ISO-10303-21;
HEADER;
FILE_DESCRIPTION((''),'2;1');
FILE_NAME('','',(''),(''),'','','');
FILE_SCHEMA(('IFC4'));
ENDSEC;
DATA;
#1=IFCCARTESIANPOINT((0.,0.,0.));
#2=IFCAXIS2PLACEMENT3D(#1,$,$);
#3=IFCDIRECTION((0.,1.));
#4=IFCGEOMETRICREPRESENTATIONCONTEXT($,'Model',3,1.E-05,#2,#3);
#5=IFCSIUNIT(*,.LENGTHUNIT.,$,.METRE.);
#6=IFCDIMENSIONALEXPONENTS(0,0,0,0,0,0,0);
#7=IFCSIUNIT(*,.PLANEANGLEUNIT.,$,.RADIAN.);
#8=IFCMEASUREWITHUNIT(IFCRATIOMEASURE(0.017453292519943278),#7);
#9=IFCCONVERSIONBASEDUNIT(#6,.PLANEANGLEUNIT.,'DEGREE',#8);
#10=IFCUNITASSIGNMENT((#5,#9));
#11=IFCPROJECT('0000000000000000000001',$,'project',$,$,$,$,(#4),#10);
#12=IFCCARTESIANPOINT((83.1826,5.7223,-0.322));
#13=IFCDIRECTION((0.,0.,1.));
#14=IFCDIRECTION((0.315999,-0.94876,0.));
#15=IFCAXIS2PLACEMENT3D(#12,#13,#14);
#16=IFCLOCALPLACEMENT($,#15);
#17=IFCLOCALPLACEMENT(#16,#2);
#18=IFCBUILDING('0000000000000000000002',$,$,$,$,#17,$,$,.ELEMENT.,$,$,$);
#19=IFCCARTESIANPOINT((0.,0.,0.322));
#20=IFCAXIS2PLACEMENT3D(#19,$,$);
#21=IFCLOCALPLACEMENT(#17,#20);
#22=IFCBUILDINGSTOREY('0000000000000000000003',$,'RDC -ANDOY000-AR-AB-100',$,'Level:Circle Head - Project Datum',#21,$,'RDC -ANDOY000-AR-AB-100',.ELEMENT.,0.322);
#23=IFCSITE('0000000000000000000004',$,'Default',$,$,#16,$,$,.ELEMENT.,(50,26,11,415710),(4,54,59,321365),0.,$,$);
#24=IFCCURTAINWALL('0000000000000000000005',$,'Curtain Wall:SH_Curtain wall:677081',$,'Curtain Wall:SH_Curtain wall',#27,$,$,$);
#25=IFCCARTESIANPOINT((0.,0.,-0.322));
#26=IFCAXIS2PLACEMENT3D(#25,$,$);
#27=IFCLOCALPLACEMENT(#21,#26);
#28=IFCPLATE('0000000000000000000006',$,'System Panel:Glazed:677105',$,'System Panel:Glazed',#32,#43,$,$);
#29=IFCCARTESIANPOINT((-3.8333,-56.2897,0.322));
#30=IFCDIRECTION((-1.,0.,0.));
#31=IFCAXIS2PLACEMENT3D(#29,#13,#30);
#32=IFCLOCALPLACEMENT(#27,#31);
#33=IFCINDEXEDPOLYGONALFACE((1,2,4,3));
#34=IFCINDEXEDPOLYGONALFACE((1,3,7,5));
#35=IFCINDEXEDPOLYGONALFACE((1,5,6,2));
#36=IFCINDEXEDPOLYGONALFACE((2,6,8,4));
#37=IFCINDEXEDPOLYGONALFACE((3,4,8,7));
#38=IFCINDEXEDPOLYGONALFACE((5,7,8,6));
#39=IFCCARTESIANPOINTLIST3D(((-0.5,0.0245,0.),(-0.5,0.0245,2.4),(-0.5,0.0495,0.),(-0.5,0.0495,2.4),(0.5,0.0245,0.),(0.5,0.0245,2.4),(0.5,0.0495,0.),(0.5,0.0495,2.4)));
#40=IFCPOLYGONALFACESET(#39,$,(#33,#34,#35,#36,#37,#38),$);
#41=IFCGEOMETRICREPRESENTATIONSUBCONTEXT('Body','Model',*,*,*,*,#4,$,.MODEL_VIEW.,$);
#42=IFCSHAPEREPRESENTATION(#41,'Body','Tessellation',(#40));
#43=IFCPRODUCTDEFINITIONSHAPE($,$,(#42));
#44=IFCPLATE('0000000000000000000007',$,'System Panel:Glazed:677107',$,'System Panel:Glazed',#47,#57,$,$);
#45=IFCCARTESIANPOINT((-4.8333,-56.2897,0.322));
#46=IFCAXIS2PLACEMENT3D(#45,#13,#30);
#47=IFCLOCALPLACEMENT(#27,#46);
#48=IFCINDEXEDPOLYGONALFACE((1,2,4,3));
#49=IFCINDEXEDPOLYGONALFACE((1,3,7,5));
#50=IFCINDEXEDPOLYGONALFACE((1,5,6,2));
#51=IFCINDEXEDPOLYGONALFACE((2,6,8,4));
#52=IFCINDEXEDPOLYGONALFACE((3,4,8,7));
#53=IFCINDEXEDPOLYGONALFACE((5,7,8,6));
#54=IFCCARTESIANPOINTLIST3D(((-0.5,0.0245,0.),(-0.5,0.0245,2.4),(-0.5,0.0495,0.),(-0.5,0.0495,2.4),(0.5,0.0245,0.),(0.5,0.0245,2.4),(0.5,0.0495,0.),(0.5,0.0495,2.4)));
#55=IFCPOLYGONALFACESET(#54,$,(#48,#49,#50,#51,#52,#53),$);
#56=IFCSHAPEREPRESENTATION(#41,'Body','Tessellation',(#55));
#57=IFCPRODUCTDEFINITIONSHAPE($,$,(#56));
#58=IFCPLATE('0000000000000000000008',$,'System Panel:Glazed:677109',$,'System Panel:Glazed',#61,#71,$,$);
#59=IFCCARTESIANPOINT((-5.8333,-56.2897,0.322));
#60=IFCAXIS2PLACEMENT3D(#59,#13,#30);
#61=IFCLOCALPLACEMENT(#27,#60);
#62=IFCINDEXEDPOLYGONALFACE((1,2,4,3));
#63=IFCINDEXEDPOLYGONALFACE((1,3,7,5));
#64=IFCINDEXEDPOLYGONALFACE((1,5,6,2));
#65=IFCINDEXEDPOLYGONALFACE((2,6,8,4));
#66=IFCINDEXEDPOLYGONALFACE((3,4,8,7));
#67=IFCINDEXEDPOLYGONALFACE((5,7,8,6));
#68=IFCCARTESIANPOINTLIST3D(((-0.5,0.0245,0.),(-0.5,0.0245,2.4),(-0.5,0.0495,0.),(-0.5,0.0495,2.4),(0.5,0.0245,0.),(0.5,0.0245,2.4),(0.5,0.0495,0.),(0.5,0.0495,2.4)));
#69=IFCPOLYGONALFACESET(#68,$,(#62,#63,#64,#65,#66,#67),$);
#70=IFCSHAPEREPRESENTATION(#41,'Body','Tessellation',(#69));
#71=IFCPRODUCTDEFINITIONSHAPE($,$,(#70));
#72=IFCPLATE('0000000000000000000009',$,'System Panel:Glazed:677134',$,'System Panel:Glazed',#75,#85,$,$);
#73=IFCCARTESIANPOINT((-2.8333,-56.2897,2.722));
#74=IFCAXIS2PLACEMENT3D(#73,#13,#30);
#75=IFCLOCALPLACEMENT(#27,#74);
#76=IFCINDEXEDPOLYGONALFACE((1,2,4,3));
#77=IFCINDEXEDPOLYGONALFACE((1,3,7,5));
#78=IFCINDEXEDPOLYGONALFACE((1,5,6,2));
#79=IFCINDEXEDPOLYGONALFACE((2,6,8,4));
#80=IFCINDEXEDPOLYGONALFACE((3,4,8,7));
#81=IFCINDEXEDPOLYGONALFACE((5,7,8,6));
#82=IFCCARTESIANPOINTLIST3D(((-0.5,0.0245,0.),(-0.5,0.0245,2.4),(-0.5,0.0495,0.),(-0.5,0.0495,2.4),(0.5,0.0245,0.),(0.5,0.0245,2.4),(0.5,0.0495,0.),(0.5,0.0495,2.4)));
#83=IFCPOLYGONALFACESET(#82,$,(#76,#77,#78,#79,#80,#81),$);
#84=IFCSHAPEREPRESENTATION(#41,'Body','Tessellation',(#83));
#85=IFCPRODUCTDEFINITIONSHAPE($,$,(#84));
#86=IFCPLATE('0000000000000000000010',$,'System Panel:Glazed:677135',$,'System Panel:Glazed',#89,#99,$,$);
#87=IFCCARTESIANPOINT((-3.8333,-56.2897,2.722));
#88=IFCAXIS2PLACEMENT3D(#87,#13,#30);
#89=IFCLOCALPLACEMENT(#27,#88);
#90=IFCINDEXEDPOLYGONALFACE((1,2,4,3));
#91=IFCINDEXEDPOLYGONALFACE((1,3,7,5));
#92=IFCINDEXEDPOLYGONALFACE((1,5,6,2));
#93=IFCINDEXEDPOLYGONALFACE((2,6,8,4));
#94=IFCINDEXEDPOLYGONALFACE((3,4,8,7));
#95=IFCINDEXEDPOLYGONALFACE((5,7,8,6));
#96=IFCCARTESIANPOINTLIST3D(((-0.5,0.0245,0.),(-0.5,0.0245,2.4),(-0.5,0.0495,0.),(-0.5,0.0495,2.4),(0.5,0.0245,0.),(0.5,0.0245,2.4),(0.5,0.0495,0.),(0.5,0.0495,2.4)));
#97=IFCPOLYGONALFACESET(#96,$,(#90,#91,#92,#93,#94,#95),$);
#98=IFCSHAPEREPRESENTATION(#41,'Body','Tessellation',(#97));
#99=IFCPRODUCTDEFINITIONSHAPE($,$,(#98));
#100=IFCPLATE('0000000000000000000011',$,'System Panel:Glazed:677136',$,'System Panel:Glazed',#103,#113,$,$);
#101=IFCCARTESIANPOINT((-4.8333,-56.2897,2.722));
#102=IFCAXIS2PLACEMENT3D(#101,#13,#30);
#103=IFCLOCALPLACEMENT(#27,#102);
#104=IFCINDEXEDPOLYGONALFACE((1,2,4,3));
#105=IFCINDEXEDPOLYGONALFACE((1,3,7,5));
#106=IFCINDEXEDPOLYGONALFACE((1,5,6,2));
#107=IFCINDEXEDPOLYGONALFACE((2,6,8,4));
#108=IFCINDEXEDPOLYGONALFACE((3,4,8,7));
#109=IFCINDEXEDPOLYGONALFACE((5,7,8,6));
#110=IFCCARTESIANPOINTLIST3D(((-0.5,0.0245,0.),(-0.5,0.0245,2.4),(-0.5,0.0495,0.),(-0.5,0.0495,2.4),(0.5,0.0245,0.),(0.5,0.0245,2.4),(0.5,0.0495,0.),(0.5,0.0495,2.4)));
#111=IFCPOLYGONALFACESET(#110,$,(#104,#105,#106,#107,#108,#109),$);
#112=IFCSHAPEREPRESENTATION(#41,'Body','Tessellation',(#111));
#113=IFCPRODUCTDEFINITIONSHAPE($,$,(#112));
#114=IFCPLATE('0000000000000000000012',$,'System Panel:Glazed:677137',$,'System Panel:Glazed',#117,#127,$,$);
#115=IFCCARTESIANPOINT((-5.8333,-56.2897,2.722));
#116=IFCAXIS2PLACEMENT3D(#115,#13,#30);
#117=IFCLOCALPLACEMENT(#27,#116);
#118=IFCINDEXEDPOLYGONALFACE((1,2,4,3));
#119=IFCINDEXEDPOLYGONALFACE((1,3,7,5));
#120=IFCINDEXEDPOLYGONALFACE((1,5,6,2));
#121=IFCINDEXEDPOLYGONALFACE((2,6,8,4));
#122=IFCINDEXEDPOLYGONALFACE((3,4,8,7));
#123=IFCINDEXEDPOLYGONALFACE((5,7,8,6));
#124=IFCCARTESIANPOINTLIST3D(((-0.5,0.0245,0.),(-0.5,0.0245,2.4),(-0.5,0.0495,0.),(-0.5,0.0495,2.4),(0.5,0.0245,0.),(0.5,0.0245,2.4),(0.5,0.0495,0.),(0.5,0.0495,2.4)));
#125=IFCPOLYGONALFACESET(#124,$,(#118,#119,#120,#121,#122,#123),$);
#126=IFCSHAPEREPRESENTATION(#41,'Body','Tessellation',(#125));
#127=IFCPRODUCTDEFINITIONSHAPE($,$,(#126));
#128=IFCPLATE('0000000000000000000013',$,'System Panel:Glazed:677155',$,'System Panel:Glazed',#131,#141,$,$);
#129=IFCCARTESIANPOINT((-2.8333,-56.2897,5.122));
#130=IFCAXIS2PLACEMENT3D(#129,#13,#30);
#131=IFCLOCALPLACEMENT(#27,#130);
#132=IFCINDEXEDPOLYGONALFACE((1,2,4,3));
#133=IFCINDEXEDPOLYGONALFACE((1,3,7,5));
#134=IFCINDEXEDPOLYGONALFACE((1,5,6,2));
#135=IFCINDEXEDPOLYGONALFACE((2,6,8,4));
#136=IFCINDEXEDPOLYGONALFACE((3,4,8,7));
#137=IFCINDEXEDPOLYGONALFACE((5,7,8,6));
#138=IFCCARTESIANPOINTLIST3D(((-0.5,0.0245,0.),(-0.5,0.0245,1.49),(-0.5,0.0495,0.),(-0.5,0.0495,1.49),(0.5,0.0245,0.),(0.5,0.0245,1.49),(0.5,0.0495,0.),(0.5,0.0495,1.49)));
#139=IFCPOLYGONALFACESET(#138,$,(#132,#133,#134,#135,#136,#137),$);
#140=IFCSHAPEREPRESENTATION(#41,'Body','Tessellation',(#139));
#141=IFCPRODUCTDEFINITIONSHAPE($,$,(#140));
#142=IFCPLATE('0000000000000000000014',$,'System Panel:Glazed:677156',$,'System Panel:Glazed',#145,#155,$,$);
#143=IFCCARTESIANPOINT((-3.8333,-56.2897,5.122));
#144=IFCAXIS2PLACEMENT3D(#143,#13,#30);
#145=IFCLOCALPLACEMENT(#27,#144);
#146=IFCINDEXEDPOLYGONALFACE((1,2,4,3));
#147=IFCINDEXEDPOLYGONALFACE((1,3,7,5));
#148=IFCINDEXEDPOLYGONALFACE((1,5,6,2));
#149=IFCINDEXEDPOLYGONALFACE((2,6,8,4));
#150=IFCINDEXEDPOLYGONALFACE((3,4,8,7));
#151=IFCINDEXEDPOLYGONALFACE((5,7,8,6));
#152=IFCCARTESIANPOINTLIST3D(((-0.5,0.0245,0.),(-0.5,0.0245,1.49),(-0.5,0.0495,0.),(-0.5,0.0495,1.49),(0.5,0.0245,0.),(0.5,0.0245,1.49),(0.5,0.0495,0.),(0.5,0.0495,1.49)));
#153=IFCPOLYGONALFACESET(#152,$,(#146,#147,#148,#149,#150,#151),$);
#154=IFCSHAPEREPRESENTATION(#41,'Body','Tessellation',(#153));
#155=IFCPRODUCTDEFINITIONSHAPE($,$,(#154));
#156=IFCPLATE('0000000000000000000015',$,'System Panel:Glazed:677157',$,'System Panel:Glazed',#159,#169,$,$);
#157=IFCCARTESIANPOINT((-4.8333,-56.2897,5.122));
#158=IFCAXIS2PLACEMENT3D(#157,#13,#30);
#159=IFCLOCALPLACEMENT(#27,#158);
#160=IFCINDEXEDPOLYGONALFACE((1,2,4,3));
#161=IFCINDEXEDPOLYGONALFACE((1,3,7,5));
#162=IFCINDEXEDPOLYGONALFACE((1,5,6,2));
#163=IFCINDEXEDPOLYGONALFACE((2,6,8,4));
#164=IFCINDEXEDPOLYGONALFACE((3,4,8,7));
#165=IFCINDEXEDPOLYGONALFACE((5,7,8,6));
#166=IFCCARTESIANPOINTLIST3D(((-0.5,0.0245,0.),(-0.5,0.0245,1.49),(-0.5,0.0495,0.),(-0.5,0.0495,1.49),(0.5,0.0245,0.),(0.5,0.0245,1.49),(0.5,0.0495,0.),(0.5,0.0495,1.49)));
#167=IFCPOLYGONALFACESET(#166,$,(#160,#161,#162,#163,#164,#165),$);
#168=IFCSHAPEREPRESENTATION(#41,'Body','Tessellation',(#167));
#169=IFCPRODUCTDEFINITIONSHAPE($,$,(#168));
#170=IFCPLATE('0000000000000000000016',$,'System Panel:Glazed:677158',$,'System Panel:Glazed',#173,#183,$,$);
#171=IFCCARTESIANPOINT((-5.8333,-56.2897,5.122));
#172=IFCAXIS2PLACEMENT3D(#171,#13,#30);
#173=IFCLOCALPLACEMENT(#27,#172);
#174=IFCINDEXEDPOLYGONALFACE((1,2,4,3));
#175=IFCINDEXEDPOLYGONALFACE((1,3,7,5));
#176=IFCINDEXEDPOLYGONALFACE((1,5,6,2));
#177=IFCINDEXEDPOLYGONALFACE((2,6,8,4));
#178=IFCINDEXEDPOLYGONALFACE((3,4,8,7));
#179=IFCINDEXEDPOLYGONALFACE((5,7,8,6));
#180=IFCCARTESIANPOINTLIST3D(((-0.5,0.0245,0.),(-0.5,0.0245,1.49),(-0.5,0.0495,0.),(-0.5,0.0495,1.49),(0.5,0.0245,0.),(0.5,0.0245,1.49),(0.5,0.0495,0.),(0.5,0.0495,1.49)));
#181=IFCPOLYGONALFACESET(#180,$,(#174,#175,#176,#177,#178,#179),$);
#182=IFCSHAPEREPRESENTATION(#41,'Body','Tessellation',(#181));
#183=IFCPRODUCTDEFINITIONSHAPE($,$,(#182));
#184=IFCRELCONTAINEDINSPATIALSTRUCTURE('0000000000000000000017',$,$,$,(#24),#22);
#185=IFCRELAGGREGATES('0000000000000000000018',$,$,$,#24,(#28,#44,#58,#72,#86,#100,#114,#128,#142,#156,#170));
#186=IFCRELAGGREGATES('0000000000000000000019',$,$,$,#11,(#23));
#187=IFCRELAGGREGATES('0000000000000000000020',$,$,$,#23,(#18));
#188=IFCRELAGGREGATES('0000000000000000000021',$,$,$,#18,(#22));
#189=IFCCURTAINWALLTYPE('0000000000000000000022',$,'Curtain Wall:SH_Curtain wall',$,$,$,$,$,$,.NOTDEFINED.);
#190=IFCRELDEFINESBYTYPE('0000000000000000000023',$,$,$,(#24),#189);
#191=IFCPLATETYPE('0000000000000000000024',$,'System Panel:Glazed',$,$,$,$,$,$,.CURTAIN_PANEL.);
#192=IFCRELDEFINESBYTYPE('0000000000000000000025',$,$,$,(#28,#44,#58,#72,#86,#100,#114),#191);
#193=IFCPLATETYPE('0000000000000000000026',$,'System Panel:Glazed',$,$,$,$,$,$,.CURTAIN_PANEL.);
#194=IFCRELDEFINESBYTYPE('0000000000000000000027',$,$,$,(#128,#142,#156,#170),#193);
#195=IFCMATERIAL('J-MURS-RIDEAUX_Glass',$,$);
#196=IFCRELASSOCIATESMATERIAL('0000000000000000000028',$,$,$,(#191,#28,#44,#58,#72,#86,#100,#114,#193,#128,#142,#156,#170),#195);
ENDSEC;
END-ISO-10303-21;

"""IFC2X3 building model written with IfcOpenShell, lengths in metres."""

from ifc_helpers import new_model, entity, si_unit, converted_unit, direction, frame, frame_2d, origin, origin_2d_with_axis, place, context, subcontext, project, spatial, rectangle, extrude, source, transform, mapped, material, type_object, type_shapes, element, aggregate, save


model = new_model("IFC2X3")

# Units and contexts
model_context = context("Model", 3, precision=1e-05, world=origin(), true_north=direction((0.0, 1.0)))
body_context = subcontext(model_context, "Body", "Model", "MODEL_VIEW")
ifc_project = project(units=[si_unit("LENGTHUNIT", "METRE"), converted_unit("PLANEANGLEUNIT", "DEGREE", entity("IfcRatioMeasure", 0.017453292519943278), si_unit("PLANEANGLEUNIT", "RADIAN"), dimensions=[0, 0, 0, 0, 0, 0, 0])], contexts=[model_context])

# Site, building, storey
site_placement = place(None, frame((83.1826, 5.7223, -0.322), z_axis=(0.0, 0.0, 1.0), x_axis=(0.315999, -0.94876, 0.0)))
site = spatial("IfcSite", under=ifc_project, at=site_placement, Name="Default", CompositionType="ELEMENT", RefLatitude=(50, 26, 11, 415710), RefLongitude=(4, 54, 59, 321365), RefElevation=0.0)
building_placement = place(site_placement, origin())
building = spatial("IfcBuilding", under=site, at=building_placement, CompositionType="ELEMENT")
storey_placement = place(building_placement, frame((0.0, 0.0, 0.322)))
storey = spatial("IfcBuildingStorey", under=building, at=storey_placement, Name="RDC -ANDOY000-AR-AB-100", ObjectType="Level:Circle Head - Project Datum", LongName="RDC -ANDOY000-AR-AB-100", CompositionType="ELEMENT", Elevation=0.322)

# Curtain wall, plates
curtain_wall_type = type_object("IfcCurtainWallType", Name="Curtain Wall:SH_Curtain wall", PredefinedType="NOTDEFINED")
curtain_wall_placement = place(storey_placement, frame((0.0, 0.0, -0.322)))
curtain_wall = element("IfcCurtainWall", 1, at=curtain_wall_placement, inside=storey, type_object=curtain_wall_type, Name="Curtain Wall:SH_Curtain wall:677081", ObjectType="Curtain Wall:SH_Curtain wall")
ifc_material_1 = material(Name="J-MURS-RIDEAUX_Glass")
plate_type_1 = type_object("IfcPlateType", Name="System Panel:Glazed", PredefinedType="CURTAIN_PANEL", material=ifc_material_1)
shared_shape_1 = source(origin(), body_context, "Body", "SweptSolid", [
    extrude(rectangle(XDim=0.025, YDim=1.0, at=frame_2d((0.0, 0.0), x_axis=(1.0, 0.0))), frame((0.0, 0.037, 0.0), z_axis=(0.0, 0.0, 1.0), x_axis=(0.0, 1.0, 0.0)), (0.0, 0.0, 1.0), 2.4),
])
type_shapes(plate_type_1, [shared_shape_1])
plate_1_placement = place(curtain_wall_placement, frame((-3.8333, -56.2897, 0.322), z_axis=(0.0, 0.0, 1.0), x_axis=(-1.0, 0.0, 0.0)))
plate_1 = element("IfcPlate", 2, at=plate_1_placement, type_object=plate_type_1, material=ifc_material_1, Name="System Panel:Glazed:677105", ObjectType="System Panel:Glazed", context=body_context, shape_type="MappedRepresentation", body=[
    mapped(shared_shape_1, transform((0.0, 0.0, 0.0), scale=1.0)),
])
plate_2_placement = place(curtain_wall_placement, frame((-4.8333, -56.2897, 0.322), z_axis=(0.0, 0.0, 1.0), x_axis=(-1.0, 0.0, 0.0)))
plate_2 = element("IfcPlate", 3, at=plate_2_placement, type_object=plate_type_1, material=ifc_material_1, Name="System Panel:Glazed:677107", ObjectType="System Panel:Glazed", context=body_context, shape_type="MappedRepresentation", body=[
    mapped(shared_shape_1, transform((0.0, 0.0, 0.0), scale=1.0)),
])
plate_3_placement = place(curtain_wall_placement, frame((-5.8333, -56.2897, 0.322), z_axis=(0.0, 0.0, 1.0), x_axis=(-1.0, 0.0, 0.0)))
plate_3 = element("IfcPlate", 4, at=plate_3_placement, type_object=plate_type_1, material=ifc_material_1, Name="System Panel:Glazed:677109", ObjectType="System Panel:Glazed", context=body_context, shape_type="MappedRepresentation", body=[
    mapped(shared_shape_1, transform((0.0, 0.0, 0.0), scale=1.0)),
])
plate_4_placement = place(curtain_wall_placement, frame((-2.8333, -56.2897, 2.722), z_axis=(0.0, 0.0, 1.0), x_axis=(-1.0, 0.0, 0.0)))
plate_4 = element("IfcPlate", 5, at=plate_4_placement, type_object=plate_type_1, material=ifc_material_1, Name="System Panel:Glazed:677134", ObjectType="System Panel:Glazed", context=body_context, shape_type="MappedRepresentation", body=[
    mapped(shared_shape_1, transform((0.0, 0.0, 0.0), scale=1.0)),
])
plate_5_placement = place(curtain_wall_placement, frame((-3.8333, -56.2897, 2.722), z_axis=(0.0, 0.0, 1.0), x_axis=(-1.0, 0.0, 0.0)))
plate_5 = element("IfcPlate", 6, at=plate_5_placement, type_object=plate_type_1, material=ifc_material_1, Name="System Panel:Glazed:677135", ObjectType="System Panel:Glazed", context=body_context, shape_type="MappedRepresentation", body=[
    mapped(shared_shape_1, transform((0.0, 0.0, 0.0), scale=1.0)),
])
plate_6_placement = place(curtain_wall_placement, frame((-4.8333, -56.2897, 2.722), z_axis=(0.0, 0.0, 1.0), x_axis=(-1.0, 0.0, 0.0)))
plate_6 = element("IfcPlate", 7, at=plate_6_placement, type_object=plate_type_1, material=ifc_material_1, Name="System Panel:Glazed:677136", ObjectType="System Panel:Glazed", context=body_context, shape_type="MappedRepresentation", body=[
    mapped(shared_shape_1, transform((0.0, 0.0, 0.0), scale=1.0)),
])
plate_7_placement = place(curtain_wall_placement, frame((-5.8333, -56.2897, 2.722), z_axis=(0.0, 0.0, 1.0), x_axis=(-1.0, 0.0, 0.0)))
plate_7 = element("IfcPlate", 8, at=plate_7_placement, type_object=plate_type_1, material=ifc_material_1, Name="System Panel:Glazed:677137", ObjectType="System Panel:Glazed", context=body_context, shape_type="MappedRepresentation", body=[
    mapped(shared_shape_1, transform((0.0, 0.0, 0.0), scale=1.0)),
])
plate_type_2 = type_object("IfcPlateType", Name="System Panel:Glazed", PredefinedType="CURTAIN_PANEL", material=ifc_material_1)
shared_shape_2 = source(origin(), body_context, "Body", "SweptSolid", [
    extrude(rectangle(XDim=0.025, YDim=1.0, at=origin_2d_with_axis()), frame((0.0, 0.037, 0.0), z_axis=(0.0, 0.0, 1.0), x_axis=(0.0, 1.0, 0.0)), (0.0, 0.0, 1.0), 1.49),
])
type_shapes(plate_type_2, [shared_shape_2])
plate_8_placement = place(curtain_wall_placement, frame((-2.8333, -56.2897, 5.122), z_axis=(0.0, 0.0, 1.0), x_axis=(-1.0, 0.0, 0.0)))
plate_8 = element("IfcPlate", 9, at=plate_8_placement, type_object=plate_type_2, material=ifc_material_1, Name="System Panel:Glazed:677155", ObjectType="System Panel:Glazed", context=body_context, shape_type="MappedRepresentation", body=[
    mapped(shared_shape_2, transform((0.0, 0.0, 0.0), scale=1.0)),
])
plate_9_placement = place(curtain_wall_placement, frame((-3.8333, -56.2897, 5.122), z_axis=(0.0, 0.0, 1.0), x_axis=(-1.0, 0.0, 0.0)))
plate_9 = element("IfcPlate", 10, at=plate_9_placement, type_object=plate_type_2, material=ifc_material_1, Name="System Panel:Glazed:677156", ObjectType="System Panel:Glazed", context=body_context, shape_type="MappedRepresentation", body=[
    mapped(shared_shape_2, transform((0.0, 0.0, 0.0), scale=1.0)),
])
plate_10_placement = place(curtain_wall_placement, frame((-4.8333, -56.2897, 5.122), z_axis=(0.0, 0.0, 1.0), x_axis=(-1.0, 0.0, 0.0)))
plate_10 = element("IfcPlate", 11, at=plate_10_placement, type_object=plate_type_2, material=ifc_material_1, Name="System Panel:Glazed:677157", ObjectType="System Panel:Glazed", context=body_context, shape_type="MappedRepresentation", body=[
    mapped(shared_shape_2, transform((0.0, 0.0, 0.0), scale=1.0)),
])
plate_11_placement = place(curtain_wall_placement, frame((-5.8333, -56.2897, 5.122), z_axis=(0.0, 0.0, 1.0), x_axis=(-1.0, 0.0, 0.0)))
plate_11 = element("IfcPlate", 12, at=plate_11_placement, type_object=plate_type_2, material=ifc_material_1, Name="System Panel:Glazed:677158", ObjectType="System Panel:Glazed", context=body_context, shape_type="MappedRepresentation", body=[
    mapped(shared_shape_2, transform((0.0, 0.0, 0.0), scale=1.0)),
])
aggregate(curtain_wall, [plate_1, plate_2, plate_3, plate_4, plate_5, plate_6, plate_7, plate_8, plate_9, plate_10, plate_11])

save(model, "model.ifc")
